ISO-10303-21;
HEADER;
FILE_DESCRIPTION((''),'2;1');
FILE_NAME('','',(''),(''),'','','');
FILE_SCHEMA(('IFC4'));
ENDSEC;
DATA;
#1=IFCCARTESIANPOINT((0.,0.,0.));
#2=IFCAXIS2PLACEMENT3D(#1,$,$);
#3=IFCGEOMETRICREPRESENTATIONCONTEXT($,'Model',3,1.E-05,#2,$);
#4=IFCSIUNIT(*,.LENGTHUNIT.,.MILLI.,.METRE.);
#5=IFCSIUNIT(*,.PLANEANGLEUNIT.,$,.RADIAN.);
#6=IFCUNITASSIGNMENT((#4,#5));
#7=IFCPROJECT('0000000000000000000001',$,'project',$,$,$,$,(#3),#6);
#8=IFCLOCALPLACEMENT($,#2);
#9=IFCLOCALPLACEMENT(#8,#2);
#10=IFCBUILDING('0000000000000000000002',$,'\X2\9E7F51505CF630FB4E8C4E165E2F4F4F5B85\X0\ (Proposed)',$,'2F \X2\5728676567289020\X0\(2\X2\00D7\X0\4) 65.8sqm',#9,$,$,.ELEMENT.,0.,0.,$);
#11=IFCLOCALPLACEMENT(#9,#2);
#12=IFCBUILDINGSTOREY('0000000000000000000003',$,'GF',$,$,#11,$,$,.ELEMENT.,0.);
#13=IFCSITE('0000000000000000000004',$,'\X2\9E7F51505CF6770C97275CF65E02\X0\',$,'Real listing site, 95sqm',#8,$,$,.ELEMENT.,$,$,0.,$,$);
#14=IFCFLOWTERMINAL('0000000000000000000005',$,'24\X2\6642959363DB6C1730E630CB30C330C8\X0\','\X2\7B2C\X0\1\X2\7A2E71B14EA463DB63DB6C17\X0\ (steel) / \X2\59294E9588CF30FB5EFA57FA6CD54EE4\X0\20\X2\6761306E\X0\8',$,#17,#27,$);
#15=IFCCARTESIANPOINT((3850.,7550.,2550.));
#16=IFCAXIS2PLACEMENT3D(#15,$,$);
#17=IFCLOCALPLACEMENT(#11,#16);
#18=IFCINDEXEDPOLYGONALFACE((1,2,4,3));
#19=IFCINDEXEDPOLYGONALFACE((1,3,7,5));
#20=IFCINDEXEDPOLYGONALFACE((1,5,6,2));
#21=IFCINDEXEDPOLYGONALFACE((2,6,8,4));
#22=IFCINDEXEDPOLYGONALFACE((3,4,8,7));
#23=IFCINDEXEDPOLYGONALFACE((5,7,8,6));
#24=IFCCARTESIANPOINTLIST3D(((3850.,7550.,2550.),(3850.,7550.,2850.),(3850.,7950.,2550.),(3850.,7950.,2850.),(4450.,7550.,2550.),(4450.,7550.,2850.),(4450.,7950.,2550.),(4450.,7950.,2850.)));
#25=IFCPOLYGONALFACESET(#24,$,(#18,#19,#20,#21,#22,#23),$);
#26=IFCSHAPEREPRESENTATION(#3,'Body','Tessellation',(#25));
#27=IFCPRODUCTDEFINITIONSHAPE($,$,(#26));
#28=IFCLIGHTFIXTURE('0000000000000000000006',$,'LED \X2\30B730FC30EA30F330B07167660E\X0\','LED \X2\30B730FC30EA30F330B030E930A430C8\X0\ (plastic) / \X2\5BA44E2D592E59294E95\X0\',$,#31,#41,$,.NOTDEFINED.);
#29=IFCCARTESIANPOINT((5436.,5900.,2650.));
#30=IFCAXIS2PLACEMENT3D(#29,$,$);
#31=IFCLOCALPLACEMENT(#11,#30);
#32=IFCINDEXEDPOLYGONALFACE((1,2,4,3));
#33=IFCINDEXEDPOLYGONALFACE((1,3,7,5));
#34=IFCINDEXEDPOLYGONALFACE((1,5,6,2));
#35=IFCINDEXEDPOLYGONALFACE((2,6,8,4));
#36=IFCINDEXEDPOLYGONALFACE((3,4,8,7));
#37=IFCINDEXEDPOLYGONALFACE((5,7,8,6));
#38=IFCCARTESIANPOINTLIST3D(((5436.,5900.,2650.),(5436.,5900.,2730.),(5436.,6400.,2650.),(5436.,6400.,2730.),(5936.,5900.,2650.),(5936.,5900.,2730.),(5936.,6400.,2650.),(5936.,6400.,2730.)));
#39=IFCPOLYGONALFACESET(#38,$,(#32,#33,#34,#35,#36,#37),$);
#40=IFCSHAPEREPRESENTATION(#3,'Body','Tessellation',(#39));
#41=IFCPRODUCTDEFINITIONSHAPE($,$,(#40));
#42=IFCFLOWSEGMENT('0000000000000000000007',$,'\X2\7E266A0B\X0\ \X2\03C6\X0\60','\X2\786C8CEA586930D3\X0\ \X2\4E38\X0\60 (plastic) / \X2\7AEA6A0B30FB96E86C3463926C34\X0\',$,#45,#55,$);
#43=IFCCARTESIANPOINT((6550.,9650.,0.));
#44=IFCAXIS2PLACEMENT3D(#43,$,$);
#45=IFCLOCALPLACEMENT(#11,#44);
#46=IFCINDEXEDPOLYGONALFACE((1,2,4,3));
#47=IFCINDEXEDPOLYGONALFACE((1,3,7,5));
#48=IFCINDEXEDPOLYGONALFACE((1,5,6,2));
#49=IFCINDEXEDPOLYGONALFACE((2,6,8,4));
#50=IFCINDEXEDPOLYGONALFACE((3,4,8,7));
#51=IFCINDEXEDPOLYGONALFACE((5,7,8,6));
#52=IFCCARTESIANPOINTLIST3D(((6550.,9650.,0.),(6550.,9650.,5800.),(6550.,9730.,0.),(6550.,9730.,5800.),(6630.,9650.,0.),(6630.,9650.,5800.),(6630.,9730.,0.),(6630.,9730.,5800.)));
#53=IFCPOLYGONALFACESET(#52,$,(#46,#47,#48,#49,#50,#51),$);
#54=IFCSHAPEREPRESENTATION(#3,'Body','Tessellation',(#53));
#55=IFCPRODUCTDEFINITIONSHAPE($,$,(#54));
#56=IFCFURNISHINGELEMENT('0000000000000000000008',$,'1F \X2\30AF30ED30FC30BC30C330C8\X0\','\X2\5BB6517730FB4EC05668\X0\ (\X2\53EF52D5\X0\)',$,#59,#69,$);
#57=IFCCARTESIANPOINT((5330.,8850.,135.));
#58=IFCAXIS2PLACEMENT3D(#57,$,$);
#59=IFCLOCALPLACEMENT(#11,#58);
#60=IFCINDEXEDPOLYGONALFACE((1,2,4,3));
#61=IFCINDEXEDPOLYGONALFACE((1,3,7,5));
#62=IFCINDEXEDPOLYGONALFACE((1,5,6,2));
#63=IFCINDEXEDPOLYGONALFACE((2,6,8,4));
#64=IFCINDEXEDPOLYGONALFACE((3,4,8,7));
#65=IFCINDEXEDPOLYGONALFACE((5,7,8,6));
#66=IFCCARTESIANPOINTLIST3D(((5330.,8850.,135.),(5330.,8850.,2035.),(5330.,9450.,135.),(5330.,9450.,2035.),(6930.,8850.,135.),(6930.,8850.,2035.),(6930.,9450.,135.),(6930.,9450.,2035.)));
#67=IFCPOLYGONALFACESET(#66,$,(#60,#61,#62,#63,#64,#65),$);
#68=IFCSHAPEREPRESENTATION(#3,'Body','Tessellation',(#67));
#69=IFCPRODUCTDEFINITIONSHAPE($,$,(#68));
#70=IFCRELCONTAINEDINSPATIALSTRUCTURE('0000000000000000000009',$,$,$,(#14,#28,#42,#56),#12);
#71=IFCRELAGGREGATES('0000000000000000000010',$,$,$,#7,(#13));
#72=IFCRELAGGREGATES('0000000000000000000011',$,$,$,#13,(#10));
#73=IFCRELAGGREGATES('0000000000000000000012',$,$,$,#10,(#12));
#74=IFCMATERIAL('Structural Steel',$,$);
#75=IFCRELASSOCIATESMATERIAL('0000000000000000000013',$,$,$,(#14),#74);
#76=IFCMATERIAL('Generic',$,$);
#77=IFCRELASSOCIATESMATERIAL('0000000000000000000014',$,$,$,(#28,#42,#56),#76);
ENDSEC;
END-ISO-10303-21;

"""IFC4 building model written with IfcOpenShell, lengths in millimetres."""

from ifc_helpers import new_model, si_unit, frame, frame_2d, origin, place, context, project, spatial, rectangle, extrude, material, element, save


model = new_model("IFC4")

# Units and contexts
model_context = context("Model", 3, precision=1e-05, world=origin())
ifc_project = project(units=[si_unit("LENGTHUNIT", "METRE", prefix="MILLI"), si_unit("PLANEANGLEUNIT", "RADIAN")], contexts=[model_context])

# Site, building, storey
site_placement = place(None, origin())
site = spatial("IfcSite", under=ifc_project, at=site_placement, Name="鹿児島県霧島市", ObjectType="Real listing site, 95sqm", CompositionType="ELEMENT", RefElevation=0.0)
building_placement = place(site_placement, origin())
building = spatial("IfcBuilding", under=site, at=building_placement, Name="鹿児島・二世帯住宅 (Proposed)", ObjectType="2F 在来木造(2×4) 65.8sqm", CompositionType="ELEMENT", ElevationOfRefHeight=0.0, ElevationOfTerrain=0.0)
storey_placement = place(building_placement, origin())
storey = spatial("IfcBuildingStorey", under=building, at=storey_placement, Name="GF", CompositionType="ELEMENT", Elevation=0.0)

# Shared definitions
ifc_material_1 = material(Name="Generic")

# Flow terminal
ifc_material_2 = material(Name="Structural Steel")
flow_terminal_placement = place(storey_placement, frame((3850.0, 7550.0, 2550.0)))
element("IfcFlowTerminal", 1, at=flow_terminal_placement, inside=storey, material=ifc_material_2, Name="24時間換気ユニット", Description="第1種熱交換換気 (steel) / 天井裏・建基法令20条の8", context=model_context, shape_type="SweptSolid", body=[
    extrude(rectangle(XDim=600.0, YDim=400.0, at=frame_2d((300.0, 200.0))), frame((3850.0, 7550.0, 2550.0)), (0.0, 0.0, 1.0), 300.0),
])

# Light fixture
light_fixture_placement = place(storey_placement, frame((5436.0, 5900.0, 2650.0)))
element("IfcLightFixture", 2, at=light_fixture_placement, inside=storey, material=ifc_material_1, Name="LED シーリング照明", Description="LED シーリングライト (plastic) / 室中央天井", PredefinedType="NOTDEFINED", context=model_context, shape_type="SweptSolid", body=[
    extrude(rectangle(XDim=500.0, YDim=500.0, at=frame_2d((250.0, 250.0))), frame((5436.0, 5900.0, 2650.0)), (0.0, 0.0, 1.0), 80.0),
])

# Flow segment
flow_segment_placement = place(storey_placement, frame((6550.0, 9650.0, 0.0)))
element("IfcFlowSegment", 3, at=flow_segment_placement, inside=storey, material=ifc_material_1, Name="縦樋 φ60", Description="硬質塩ビ 丸60 (plastic) / 竪樋・雨水排水", context=model_context, shape_type="SweptSolid", body=[
    extrude(rectangle(XDim=80.0, YDim=80.0, at=frame_2d((40.0, 40.0))), frame((6550.0, 9650.0, 0.0)), (0.0, 0.0, 1.0), 5800.0),
])

# Furnishing element
furnishing_placement = place(storey_placement, frame((5330.0, 8850.0, 135.0)))
element("IfcFurnishingElement", 4, at=furnishing_placement, inside=storey, material=ifc_material_1, Name="1F クローゼット", Description="家具・什器 (可動)", context=model_context, shape_type="SweptSolid", body=[
    extrude(rectangle(XDim=1600.0, YDim=600.0, at=frame_2d((800.0, 300.0))), frame((5330.0, 8850.0, 135.0)), (0.0, 0.0, 1.0), 1900.0),
])

save(model, "model.ifc")
